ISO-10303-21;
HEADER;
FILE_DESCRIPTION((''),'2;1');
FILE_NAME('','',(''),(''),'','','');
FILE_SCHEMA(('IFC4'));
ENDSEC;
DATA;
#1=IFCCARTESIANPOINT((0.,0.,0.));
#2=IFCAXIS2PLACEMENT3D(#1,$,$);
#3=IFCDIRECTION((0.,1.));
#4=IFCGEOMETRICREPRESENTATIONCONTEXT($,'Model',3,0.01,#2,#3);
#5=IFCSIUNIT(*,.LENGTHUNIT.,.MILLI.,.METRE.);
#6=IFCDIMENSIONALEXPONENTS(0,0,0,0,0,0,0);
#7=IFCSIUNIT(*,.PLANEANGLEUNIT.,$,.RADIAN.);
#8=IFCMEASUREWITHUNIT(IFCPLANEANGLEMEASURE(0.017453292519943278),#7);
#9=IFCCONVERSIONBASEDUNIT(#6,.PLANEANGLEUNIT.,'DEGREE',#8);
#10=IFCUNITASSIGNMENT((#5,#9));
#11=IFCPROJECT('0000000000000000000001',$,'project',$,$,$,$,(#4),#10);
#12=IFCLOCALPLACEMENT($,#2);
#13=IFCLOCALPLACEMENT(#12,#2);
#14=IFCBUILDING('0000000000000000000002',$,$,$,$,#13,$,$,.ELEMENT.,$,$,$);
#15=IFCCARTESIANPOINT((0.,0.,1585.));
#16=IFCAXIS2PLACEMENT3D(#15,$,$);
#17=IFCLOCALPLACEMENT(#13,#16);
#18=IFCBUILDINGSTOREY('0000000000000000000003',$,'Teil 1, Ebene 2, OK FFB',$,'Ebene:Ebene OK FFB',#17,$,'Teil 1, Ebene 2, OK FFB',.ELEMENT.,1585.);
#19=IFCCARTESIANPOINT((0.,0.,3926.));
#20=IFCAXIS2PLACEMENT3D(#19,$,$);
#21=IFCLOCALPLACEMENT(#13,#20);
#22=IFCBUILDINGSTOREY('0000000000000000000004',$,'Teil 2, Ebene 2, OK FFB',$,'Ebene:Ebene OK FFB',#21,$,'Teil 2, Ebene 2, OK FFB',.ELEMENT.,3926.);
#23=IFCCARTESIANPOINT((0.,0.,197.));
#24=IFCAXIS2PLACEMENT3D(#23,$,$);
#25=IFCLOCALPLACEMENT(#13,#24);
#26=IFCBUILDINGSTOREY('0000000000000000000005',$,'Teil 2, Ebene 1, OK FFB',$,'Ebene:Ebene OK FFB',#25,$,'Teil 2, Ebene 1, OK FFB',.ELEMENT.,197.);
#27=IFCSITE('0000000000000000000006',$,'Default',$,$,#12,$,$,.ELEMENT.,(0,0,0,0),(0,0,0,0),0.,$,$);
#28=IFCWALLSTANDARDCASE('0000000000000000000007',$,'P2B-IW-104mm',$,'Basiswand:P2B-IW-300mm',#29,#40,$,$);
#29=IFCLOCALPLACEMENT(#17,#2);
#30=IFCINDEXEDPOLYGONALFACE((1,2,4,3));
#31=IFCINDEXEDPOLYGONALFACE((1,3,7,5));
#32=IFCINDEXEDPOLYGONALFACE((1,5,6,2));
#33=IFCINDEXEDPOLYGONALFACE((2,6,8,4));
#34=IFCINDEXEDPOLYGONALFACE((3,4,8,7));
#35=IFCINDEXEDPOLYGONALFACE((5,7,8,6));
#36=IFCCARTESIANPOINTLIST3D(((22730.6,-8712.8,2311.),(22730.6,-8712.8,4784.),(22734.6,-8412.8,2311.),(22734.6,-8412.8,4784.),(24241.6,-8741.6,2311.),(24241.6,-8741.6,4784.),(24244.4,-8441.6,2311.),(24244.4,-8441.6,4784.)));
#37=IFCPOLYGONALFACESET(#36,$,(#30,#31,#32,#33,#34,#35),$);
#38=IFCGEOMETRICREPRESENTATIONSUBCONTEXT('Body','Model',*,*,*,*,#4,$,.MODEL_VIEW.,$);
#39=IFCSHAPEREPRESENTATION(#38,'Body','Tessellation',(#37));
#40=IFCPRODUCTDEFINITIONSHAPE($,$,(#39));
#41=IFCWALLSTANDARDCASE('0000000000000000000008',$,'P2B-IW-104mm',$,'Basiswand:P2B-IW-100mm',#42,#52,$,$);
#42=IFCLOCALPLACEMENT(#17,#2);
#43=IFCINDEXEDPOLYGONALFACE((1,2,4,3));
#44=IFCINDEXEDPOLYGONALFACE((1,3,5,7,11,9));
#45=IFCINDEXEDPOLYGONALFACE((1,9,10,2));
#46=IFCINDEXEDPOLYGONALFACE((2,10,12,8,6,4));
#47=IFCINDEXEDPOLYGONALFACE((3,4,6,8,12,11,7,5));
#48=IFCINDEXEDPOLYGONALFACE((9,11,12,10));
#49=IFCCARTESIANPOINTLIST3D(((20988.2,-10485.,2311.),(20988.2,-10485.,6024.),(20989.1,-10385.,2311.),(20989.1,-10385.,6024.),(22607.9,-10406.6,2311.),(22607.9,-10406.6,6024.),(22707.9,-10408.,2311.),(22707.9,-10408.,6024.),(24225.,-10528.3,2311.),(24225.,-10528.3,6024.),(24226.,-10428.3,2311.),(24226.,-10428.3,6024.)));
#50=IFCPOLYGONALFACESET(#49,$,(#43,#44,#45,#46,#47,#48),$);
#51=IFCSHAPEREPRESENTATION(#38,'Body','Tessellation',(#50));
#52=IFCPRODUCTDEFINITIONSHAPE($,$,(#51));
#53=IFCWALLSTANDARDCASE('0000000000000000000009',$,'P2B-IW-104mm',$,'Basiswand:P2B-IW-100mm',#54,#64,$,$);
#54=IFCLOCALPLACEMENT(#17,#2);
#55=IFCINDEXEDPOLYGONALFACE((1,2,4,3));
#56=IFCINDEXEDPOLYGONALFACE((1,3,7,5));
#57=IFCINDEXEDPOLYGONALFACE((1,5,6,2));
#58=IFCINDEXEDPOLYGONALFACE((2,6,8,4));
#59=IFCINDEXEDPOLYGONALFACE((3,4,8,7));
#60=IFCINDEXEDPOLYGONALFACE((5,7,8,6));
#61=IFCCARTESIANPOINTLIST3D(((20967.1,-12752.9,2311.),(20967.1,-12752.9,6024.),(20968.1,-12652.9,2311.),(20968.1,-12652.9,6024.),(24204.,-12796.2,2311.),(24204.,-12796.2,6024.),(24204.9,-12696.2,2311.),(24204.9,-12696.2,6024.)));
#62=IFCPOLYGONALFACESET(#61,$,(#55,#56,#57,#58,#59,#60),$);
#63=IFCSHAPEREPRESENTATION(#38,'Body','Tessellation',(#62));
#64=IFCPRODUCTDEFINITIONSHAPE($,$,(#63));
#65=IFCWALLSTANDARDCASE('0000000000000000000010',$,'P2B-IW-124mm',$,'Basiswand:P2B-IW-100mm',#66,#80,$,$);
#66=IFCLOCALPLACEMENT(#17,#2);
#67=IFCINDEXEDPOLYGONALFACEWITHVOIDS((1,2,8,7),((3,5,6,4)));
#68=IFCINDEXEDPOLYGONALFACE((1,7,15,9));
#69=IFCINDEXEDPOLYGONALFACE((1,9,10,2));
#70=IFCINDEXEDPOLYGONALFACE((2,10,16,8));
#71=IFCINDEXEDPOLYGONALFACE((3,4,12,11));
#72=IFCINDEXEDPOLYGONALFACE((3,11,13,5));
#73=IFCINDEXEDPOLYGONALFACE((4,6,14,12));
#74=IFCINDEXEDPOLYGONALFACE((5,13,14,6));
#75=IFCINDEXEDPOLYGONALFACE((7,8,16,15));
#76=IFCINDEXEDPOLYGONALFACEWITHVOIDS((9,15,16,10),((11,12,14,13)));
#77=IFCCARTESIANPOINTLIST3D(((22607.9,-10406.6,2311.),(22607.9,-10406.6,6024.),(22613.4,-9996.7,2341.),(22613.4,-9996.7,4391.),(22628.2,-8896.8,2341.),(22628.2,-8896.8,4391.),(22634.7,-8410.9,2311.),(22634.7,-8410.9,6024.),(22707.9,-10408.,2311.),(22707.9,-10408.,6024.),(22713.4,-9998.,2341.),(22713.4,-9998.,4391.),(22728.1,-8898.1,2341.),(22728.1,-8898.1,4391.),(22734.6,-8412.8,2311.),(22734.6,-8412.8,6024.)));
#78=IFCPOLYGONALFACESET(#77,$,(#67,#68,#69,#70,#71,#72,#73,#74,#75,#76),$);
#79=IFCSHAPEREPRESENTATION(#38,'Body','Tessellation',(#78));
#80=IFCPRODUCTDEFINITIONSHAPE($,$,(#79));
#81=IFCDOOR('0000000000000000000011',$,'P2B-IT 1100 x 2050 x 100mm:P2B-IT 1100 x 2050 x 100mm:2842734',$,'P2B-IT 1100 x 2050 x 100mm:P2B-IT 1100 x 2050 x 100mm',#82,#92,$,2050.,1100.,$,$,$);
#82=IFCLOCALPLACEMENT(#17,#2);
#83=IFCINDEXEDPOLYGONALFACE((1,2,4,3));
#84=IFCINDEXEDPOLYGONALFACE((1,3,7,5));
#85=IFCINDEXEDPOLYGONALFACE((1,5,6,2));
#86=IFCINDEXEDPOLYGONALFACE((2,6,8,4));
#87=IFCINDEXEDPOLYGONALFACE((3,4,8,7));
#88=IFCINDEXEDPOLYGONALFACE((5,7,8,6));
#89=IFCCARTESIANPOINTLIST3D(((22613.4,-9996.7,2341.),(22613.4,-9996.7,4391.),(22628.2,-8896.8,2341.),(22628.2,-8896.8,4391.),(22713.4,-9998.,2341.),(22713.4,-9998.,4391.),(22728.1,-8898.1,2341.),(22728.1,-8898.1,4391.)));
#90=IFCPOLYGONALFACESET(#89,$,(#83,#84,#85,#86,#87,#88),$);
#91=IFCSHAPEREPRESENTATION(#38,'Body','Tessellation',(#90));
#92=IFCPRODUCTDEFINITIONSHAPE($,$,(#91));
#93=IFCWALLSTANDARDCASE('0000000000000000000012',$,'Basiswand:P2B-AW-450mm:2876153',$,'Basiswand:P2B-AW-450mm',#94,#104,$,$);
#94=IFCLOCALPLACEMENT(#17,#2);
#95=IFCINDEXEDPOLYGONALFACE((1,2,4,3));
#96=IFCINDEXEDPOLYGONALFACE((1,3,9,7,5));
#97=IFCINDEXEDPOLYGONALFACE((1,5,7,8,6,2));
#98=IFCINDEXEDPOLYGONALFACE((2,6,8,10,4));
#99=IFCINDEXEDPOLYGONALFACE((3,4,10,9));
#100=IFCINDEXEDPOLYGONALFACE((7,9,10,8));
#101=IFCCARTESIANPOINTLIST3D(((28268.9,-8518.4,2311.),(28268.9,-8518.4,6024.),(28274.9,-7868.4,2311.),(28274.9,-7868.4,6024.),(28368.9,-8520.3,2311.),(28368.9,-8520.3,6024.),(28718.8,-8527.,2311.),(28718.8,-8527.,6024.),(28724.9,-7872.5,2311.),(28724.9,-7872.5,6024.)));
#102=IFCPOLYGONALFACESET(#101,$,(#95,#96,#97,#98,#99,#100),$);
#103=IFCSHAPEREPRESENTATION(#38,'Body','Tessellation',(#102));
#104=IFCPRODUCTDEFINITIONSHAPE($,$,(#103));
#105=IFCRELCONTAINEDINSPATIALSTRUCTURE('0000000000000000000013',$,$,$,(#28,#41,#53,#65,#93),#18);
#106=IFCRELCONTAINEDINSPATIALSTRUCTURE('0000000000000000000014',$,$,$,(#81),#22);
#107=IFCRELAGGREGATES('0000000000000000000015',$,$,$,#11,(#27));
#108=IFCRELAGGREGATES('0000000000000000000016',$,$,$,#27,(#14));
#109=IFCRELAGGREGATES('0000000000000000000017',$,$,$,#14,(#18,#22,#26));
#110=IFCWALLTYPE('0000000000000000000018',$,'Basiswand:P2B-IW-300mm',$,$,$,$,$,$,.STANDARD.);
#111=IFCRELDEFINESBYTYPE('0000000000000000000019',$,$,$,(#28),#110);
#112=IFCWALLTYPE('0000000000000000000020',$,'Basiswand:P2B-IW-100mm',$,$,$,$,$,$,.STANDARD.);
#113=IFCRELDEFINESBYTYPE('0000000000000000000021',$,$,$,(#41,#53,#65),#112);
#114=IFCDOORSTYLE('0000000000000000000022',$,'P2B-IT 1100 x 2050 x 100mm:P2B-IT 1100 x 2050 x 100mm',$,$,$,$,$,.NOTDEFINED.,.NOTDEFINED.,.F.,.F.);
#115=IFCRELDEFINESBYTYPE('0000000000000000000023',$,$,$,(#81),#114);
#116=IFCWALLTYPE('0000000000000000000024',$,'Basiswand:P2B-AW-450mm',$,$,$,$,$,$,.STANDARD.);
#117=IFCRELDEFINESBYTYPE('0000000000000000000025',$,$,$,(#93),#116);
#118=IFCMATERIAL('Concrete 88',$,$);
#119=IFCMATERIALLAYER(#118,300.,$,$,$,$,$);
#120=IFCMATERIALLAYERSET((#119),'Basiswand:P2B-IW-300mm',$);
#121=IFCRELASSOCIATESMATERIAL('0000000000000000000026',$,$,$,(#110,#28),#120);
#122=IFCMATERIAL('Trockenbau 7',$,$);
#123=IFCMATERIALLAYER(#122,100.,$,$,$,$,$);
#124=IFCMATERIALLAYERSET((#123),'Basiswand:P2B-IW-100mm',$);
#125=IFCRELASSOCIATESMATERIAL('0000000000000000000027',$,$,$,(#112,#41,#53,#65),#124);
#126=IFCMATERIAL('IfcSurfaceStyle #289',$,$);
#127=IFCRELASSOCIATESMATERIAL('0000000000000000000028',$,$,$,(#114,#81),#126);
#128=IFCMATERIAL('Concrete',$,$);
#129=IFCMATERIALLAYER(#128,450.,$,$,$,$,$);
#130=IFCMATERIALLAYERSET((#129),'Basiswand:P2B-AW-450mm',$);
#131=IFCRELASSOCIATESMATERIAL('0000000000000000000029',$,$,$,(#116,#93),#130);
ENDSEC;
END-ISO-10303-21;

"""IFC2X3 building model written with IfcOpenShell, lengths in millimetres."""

from ifc_helpers import new_model, entity, si_unit, converted_unit, direction, frame, frame_2d, origin, origin_2d_with_axis, place, context, subcontext, project, spatial, polyline, rectangle, outline, extrude, source, transform, mapped, material, layer, layer_set, layer_usage, type_object, type_shapes, element, fill, save


model = new_model("IFC2X3")

# Units and contexts
model_context = context("Model", 3, precision=0.01, world=origin(), true_north=direction((0.0, 1.0)))
body_context = subcontext(model_context, "Body", "Model", "MODEL_VIEW")
ifc_project = project(units=[si_unit("LENGTHUNIT", "METRE", prefix="MILLI"), converted_unit("PLANEANGLEUNIT", "DEGREE", entity("IfcPlaneAngleMeasure", 0.017453292519943278), si_unit("PLANEANGLEUNIT", "RADIAN"), dimensions=[0, 0, 0, 0, 0, 0, 0])], contexts=[model_context])

# Site, building, storey
site_placement = place(None, origin())
site = spatial("IfcSite", under=ifc_project, at=site_placement, Name="Default", CompositionType="ELEMENT", RefLatitude=(0, 0, 0, 0), RefLongitude=(0, 0, 0, 0), RefElevation=0.0)
building_placement = place(site_placement, origin())
building = spatial("IfcBuilding", under=site, at=building_placement, CompositionType="ELEMENT")
storey_1_placement = place(building_placement, frame((0.0, 0.0, 1585.0)))
storey_1 = spatial("IfcBuildingStorey", under=building, at=storey_1_placement, Name="Teil 1, Ebene 2, OK FFB", ObjectType="Ebene:Ebene OK FFB", LongName="Teil 1, Ebene 2, OK FFB", CompositionType="ELEMENT", Elevation=1585.0)

# Walls
ifc_material_1 = material(Name="Concrete 88")
ifc_layer_1 = layer(ifc_material_1, 300.0)
ifc_layer_set_1 = layer_set([ifc_layer_1], Name="Basiswand:P2B-IW-300mm")
ifc_layer_usage_1 = layer_usage(ifc_layer_set_1, "AXIS2", "NEGATIVE", 150.0)
wall_type_1 = type_object("IfcWallType", Name="Basiswand:P2B-IW-300mm", PredefinedType="STANDARD", material=ifc_layer_set_1)
wall_1_placement = place(storey_1_placement, frame((24244.5, -8591.6, 2311.0), z_axis=(0.0, 0.0, 1.0), x_axis=(-0.999818, 0.019077, 0.0)))
element("IfcWallStandardCase", 1, at=wall_1_placement, inside=storey_1, type_object=wall_type_1, material=ifc_layer_usage_1, Name="P2B-IW-104mm", ObjectType="Basiswand:P2B-IW-300mm", context=body_context, shape_type="SweptSolid", body=[
    extrude(outline(polyline([(1513.0, -150.0), (1511.3, 150.0), (0.0, 150.0), (2.9, -150.0), (1513.0, -150.0)])), origin(), (0.0, 0.0, 1.0), 2473.0),
])
ifc_material_2 = material(Name="Trockenbau 7")
ifc_layer_2 = layer(ifc_material_2, 100.0)
ifc_layer_set_2 = layer_set([ifc_layer_2], Name="Basiswand:P2B-IW-100mm")
ifc_layer_usage_2 = layer_usage(ifc_layer_set_2, "AXIS2", "NEGATIVE", 50.0)
wall_type_2 = type_object("IfcWallType", Name="Basiswand:P2B-IW-100mm", PredefinedType="STANDARD", material=ifc_layer_set_2)
wall_2_placement = place(storey_1_placement, frame((24225.7, -10478.3, 2311.0), z_axis=(0.0, 0.0, 1.0), x_axis=(-0.99991, 0.013383, 0.0)))
element("IfcWallStandardCase", 2, at=wall_2_placement, inside=storey_1, type_object=wall_type_2, material=ifc_layer_usage_2, Name="P2B-IW-104mm", ObjectType="Basiswand:P2B-IW-100mm", context=body_context, shape_type="SweptSolid", body=[
    extrude(outline(polyline([(3237.5, -50.0), (3237.1, 50.0), (0.0, 50.0), (0.4, -50.0), (1518.6, -50.0), (1618.6, -50.0), (3237.5, -50.0)])), origin(), (0.0, 0.0, 1.0), 3713.0),
])
ifc_layer_usage_3 = layer_usage(ifc_layer_set_2, "AXIS2", "NEGATIVE", 50.0)
wall_3_placement = place(storey_1_placement, frame((24204.6, -12746.2, 2311.0), z_axis=(0.0, 0.0, 1.0), x_axis=(-0.99991, 0.013383, 0.0)))
element("IfcWallStandardCase", 3, at=wall_3_placement, inside=storey_1, type_object=wall_type_2, material=ifc_layer_usage_3, Name="P2B-IW-104mm", ObjectType="Basiswand:P2B-IW-100mm", context=body_context, shape_type="SweptSolid", body=[
    extrude(outline(polyline([(3237.5, -50.0), (3237.1, 50.0), (0.0, 50.0), (0.4, -50.0), (3237.5, -50.0)])), origin(), (0.0, 0.0, 1.0), 3713.0),
])

# Wall, opening
ifc_layer_usage_4 = layer_usage(ifc_layer_set_2, "AXIS2", "NEGATIVE", 50.0)
wall_4_placement = place(storey_1_placement, frame((22657.9, -10407.3, 2311.0), z_axis=(0.0, 0.0, 1.0), x_axis=(0.013383, 0.99991, 0.0)))
wall_4 = element("IfcWallStandardCase", 4, at=wall_4_placement, inside=storey_1, type_object=wall_type_2, material=ifc_layer_usage_4, Name="P2B-IW-124mm", ObjectType="Basiswand:P2B-IW-100mm", context=body_context, shape_type="SweptSolid", body=[
    extrude(outline(polyline([(1995.4, -50.0), (1996.0, 50.0), (0.0, 50.0), (0.0, -50.0), (1695.4, -50.0), (1995.4, -50.0)])), origin(), (0.0, 0.0, 1.0), 3713.0),
])
opening_1_placement = place(wall_4_placement, frame((10103.2, 22795.2, 30.0), z_axis=(0.0, 0.0, 1.0), x_axis=(0.013383, -0.99991, 0.0)))
opening_1 = element("IfcOpeningElement", 5, at=opening_1_placement, cuts=wall_4, ObjectType="Opening", context=body_context, shape_type="SweptSolid", body=[
    extrude(rectangle(XDim=2050.0, YDim=1100.0, at=frame_2d((0.0, 0.0), x_axis=(1.0, 0.0))), frame((22820.8, -9449.4, 1025.0), z_axis=(-0.99991, 0.013383, 0.0), x_axis=(0.0, 0.0, -1.0)), (0.0, 0.0, 1.0), 300.0),
])

# Shared definitions
storey_2_placement = place(building_placement, frame((0.0, 0.0, 3926.0)))
storey_2 = spatial("IfcBuildingStorey", under=building, at=storey_2_placement, Name="Teil 2, Ebene 2, OK FFB", ObjectType="Ebene:Ebene OK FFB", LongName="Teil 2, Ebene 2, OK FFB", CompositionType="ELEMENT", Elevation=3926.0)

# Door
ifc_material_3 = material(Name="IfcSurfaceStyle #289")
door_style = type_object("IfcDoorStyle", Name="P2B-IT 1100 x 2050 x 100mm:P2B-IT 1100 x 2050 x 100mm", ConstructionType="NOTDEFINED", OperationType="NOTDEFINED", ParameterTakesPrecedence=False, Sizeable=False, material=ifc_material_3)
shared_shape_1 = source(origin(), body_context, "Body", "SweptSolid", [
    extrude(rectangle(XDim=100.0, YDim=1100.0, at=origin_2d_with_axis()), frame((550.0, 150.0, 0.0), z_axis=(0.0, 0.0, 1.0), x_axis=(0.0, 1.0, 0.0)), (0.0, 0.0, 1.0), 2050.0),
])
type_shapes(door_style, [shared_shape_1])
door_placement = place(opening_1_placement, frame((22528.2, -8895.4, 0.0), z_axis=(0.0, 0.0, 1.0), x_axis=(-0.013383, -0.99991, 0.0)))
door = element("IfcDoor", 6, at=door_placement, inside=storey_2, type_object=door_style, material=ifc_material_3, Name="P2B-IT 1100 x 2050 x 100mm:P2B-IT 1100 x 2050 x 100mm:2842734", ObjectType="P2B-IT 1100 x 2050 x 100mm:P2B-IT 1100 x 2050 x 100mm", OverallHeight=2050.0, OverallWidth=1100.0, context=body_context, shape_type="MappedRepresentation", body=[
    mapped(shared_shape_1, transform((0.0, 0.0, 0.0), scale=1.0)),
])
fill(opening_1, door)

# Wall
ifc_material_4 = material(Name="Concrete")
ifc_layer_3 = layer(ifc_material_4, 450.0)
ifc_layer_set_3 = layer_set([ifc_layer_3], Name="Basiswand:P2B-AW-450mm")
ifc_layer_usage_5 = layer_usage(ifc_layer_set_3, "AXIS2", "POSITIVE", -225.0)
wall_type_3 = type_object("IfcWallType", Name="Basiswand:P2B-AW-450mm", PredefinedType="STANDARD", material=ifc_layer_set_3)
wall_5_placement = place(storey_1_placement, frame((28493.8, -8524.9, 2311.0), z_axis=(0.0, 0.0, 1.0), x_axis=(0.009291, 0.999957, 0.0)))
element("IfcWallStandardCase", 7, at=wall_5_placement, inside=storey_1, type_object=wall_type_3, material=ifc_layer_usage_5, Name="Basiswand:P2B-AW-450mm:2876153", ObjectType="Basiswand:P2B-AW-450mm", context=body_context, shape_type="SweptSolid", body=[
    extrude(outline(polyline([(654.4, -225.0), (654.4, 225.0), (4.4, 225.0), (3.4, 125.0), (0.0, -225.0), (654.4, -225.0)])), origin(), (0.0, 0.0, 1.0), 3713.0),
])

# Shared definitions
storey_3_placement = place(building_placement, frame((0.0, 0.0, 197.0)))
storey_3 = spatial("IfcBuildingStorey", under=building, at=storey_3_placement, Name="Teil 2, Ebene 1, OK FFB", ObjectType="Ebene:Ebene OK FFB", LongName="Teil 2, Ebene 1, OK FFB", CompositionType="ELEMENT", Elevation=197.0)

save(model, "model.ifc")
